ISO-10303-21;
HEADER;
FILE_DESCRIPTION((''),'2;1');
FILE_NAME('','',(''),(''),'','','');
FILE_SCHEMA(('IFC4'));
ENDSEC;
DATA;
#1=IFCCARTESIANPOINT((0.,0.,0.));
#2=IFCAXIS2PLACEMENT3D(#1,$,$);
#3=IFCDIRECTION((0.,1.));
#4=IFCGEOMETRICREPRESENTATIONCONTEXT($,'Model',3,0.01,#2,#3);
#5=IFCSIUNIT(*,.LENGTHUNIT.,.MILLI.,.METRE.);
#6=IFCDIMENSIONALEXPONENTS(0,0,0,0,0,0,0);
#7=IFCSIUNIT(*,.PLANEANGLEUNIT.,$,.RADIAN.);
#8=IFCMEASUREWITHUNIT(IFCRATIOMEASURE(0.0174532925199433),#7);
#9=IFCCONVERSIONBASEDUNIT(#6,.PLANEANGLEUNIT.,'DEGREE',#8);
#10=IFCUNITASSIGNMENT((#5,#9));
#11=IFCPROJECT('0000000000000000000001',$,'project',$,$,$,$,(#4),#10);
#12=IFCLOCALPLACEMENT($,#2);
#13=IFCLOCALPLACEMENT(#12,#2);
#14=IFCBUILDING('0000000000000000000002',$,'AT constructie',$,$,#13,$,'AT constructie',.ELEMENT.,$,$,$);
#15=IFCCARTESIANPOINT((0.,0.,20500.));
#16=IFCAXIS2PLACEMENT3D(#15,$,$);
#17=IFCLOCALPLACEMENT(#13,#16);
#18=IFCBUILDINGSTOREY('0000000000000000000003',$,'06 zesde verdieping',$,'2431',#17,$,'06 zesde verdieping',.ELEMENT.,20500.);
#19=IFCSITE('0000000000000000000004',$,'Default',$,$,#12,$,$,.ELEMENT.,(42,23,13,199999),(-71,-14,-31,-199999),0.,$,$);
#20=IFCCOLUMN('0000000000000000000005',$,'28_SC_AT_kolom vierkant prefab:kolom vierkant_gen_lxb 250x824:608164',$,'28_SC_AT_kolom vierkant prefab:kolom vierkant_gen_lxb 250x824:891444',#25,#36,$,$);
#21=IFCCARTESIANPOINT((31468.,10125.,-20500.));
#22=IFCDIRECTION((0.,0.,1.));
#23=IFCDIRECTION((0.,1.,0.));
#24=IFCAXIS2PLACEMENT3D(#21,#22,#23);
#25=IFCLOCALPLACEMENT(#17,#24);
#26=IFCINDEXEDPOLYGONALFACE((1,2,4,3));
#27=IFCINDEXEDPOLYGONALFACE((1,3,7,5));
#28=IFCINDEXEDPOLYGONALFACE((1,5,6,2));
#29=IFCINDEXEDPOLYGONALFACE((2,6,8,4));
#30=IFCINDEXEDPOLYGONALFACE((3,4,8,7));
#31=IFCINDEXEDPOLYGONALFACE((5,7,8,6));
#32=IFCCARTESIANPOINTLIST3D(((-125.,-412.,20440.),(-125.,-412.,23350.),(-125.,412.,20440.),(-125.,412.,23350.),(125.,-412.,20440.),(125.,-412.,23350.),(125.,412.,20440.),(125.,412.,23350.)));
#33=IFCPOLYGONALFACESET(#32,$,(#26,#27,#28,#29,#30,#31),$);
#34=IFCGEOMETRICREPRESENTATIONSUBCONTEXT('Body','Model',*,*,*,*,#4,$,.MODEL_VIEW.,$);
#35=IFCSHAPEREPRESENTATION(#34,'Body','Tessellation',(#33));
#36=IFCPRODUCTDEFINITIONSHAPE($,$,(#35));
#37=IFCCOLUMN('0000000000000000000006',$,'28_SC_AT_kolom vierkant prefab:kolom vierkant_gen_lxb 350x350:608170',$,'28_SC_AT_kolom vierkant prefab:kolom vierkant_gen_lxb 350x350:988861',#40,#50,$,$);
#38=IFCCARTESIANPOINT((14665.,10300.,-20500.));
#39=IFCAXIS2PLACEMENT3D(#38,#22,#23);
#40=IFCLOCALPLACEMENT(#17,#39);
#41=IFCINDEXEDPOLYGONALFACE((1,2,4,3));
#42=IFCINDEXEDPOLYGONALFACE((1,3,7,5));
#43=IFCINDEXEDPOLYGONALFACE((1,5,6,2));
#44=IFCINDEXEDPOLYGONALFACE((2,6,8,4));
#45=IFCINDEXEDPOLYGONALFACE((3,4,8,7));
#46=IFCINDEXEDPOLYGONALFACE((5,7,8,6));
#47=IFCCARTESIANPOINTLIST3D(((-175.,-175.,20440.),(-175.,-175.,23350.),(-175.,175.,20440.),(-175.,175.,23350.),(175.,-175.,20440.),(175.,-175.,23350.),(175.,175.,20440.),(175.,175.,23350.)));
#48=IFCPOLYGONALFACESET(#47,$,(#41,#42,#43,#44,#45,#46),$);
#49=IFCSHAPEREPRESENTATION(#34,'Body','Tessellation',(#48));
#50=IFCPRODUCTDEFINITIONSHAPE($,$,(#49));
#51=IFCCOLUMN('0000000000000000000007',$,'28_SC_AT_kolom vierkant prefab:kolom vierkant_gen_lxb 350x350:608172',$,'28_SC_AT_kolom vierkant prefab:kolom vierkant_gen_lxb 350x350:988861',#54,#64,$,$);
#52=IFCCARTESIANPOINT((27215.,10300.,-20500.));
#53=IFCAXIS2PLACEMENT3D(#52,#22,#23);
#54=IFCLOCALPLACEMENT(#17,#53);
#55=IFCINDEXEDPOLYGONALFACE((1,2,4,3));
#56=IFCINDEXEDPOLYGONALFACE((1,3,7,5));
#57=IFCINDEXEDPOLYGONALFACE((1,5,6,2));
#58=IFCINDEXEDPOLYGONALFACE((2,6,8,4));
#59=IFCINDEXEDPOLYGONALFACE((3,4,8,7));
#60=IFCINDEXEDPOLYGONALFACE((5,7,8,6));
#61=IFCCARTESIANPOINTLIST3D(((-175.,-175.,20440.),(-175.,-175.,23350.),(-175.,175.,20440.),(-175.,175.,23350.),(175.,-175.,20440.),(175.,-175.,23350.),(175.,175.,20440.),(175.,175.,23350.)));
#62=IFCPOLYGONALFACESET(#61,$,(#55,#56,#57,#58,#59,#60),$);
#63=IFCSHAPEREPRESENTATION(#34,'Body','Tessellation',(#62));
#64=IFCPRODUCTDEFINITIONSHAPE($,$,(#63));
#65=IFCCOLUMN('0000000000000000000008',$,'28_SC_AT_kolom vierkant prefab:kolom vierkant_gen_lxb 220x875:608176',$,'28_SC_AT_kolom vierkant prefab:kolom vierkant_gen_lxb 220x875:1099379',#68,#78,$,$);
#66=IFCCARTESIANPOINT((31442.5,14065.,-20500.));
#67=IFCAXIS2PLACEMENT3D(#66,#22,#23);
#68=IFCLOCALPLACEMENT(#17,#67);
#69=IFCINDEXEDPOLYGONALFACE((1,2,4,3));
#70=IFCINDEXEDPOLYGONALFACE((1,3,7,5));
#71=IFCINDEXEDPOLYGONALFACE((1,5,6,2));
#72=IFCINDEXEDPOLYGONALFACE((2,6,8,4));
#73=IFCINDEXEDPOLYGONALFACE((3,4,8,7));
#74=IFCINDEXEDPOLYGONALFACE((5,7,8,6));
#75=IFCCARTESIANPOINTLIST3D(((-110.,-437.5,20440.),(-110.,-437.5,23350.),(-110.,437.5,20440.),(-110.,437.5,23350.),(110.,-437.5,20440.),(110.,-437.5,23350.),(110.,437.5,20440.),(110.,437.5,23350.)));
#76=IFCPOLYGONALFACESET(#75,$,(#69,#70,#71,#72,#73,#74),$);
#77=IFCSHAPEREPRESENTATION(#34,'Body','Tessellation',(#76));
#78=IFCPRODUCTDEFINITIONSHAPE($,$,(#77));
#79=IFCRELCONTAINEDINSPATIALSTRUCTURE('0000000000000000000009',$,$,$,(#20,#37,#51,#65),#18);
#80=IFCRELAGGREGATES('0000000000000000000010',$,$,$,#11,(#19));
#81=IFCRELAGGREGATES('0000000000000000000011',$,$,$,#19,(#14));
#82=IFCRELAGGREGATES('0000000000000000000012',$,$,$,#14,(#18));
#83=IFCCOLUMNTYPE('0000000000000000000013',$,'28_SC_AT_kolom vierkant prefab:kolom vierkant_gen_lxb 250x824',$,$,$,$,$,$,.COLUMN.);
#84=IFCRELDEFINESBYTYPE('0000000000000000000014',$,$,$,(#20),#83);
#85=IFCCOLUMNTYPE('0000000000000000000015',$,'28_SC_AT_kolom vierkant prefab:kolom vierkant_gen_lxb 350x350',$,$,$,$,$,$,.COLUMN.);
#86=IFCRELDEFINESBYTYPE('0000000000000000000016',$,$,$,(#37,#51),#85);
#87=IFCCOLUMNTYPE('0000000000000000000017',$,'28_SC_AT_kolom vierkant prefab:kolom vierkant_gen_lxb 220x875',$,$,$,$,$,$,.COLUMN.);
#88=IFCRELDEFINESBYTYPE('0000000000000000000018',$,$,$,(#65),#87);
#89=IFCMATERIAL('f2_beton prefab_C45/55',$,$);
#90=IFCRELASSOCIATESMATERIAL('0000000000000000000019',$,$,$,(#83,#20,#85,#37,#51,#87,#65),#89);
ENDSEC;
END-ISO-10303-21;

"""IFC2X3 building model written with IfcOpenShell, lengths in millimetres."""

from ifc_helpers import new_model, entity, si_unit, converted_unit, direction, frame, origin, origin_2d_with_axis, place, context, subcontext, project, spatial, rectangle, extrude, source, transform, mapped, material, type_object, type_shapes, element, save


model = new_model("IFC2X3")

# Units and contexts
model_context = context("Model", 3, precision=0.01, world=origin(), true_north=direction((0.0, 1.0)))
body_context = subcontext(model_context, "Body", "Model", "MODEL_VIEW")
ifc_project = project(units=[si_unit("LENGTHUNIT", "METRE", prefix="MILLI"), converted_unit("PLANEANGLEUNIT", "DEGREE", entity("IfcRatioMeasure", 0.0174532925199433), si_unit("PLANEANGLEUNIT", "RADIAN"), dimensions=[0, 0, 0, 0, 0, 0, 0])], contexts=[model_context])

# Site, building, storey
site_placement = place(None, origin())
site = spatial("IfcSite", under=ifc_project, at=site_placement, Name="Default", CompositionType="ELEMENT", RefLatitude=(42, 23, 13, 199999), RefLongitude=(-71, -14, -31, -199999), RefElevation=0.0)
building_placement = place(site_placement, origin())
building = spatial("IfcBuilding", under=site, at=building_placement, Name="AT constructie", LongName="AT constructie", CompositionType="ELEMENT")
storey_placement = place(building_placement, frame((0.0, 0.0, 20500.0)))
storey = spatial("IfcBuildingStorey", under=building, at=storey_placement, Name="06 zesde verdieping", ObjectType="2431", LongName="06 zesde verdieping", CompositionType="ELEMENT", Elevation=20500.0)

# Columns
ifc_material_1 = material(Name="f2_beton prefab_C45/55")
column_type_1 = type_object("IfcColumnType", Name="28_SC_AT_kolom vierkant prefab:kolom vierkant_gen_lxb 250x824", PredefinedType="COLUMN", material=ifc_material_1)
shared_shape_1 = source(origin(), body_context, "Body", "SweptSolid", [
    extrude(rectangle(XDim=250.0, YDim=824.0, at=origin_2d_with_axis()), frame((0.0, 0.0, 20440.0), z_axis=(0.0, 0.0, 1.0), x_axis=(-1.0, 0.0, 0.0)), (0.0, 0.0, 1.0), 2910.0),
])
type_shapes(column_type_1, [shared_shape_1])
column_1_placement = place(storey_placement, frame((31468.0, 10125.0, -20500.0), z_axis=(0.0, 0.0, 1.0), x_axis=(0.0, 1.0, 0.0)))
element("IfcColumn", 1, at=column_1_placement, inside=storey, type_object=column_type_1, material=ifc_material_1, Name="28_SC_AT_kolom vierkant prefab:kolom vierkant_gen_lxb 250x824:608164", ObjectType="28_SC_AT_kolom vierkant prefab:kolom vierkant_gen_lxb 250x824:891444", context=body_context, shape_type="MappedRepresentation", body=[
    mapped(shared_shape_1, transform((0.0, 0.0, 0.0), scale=1.0)),
])
column_type_2 = type_object("IfcColumnType", Name="28_SC_AT_kolom vierkant prefab:kolom vierkant_gen_lxb 350x350", PredefinedType="COLUMN", material=ifc_material_1)
shared_shape_2 = source(origin(), body_context, "Body", "SweptSolid", [
    extrude(rectangle(XDim=350.0, YDim=350.0, at=origin_2d_with_axis()), frame((0.0, 0.0, 20440.0), z_axis=(0.0, 0.0, 1.0), x_axis=(-1.0, 0.0, 0.0)), (0.0, 0.0, 1.0), 2910.0),
])
type_shapes(column_type_2, [shared_shape_2])
for number, where, z_axis, x_axis, name in (
    (2, (14665.0, 10300.0, -20500.0), (0.0, 0.0, 1.0), (0.0, 1.0, 0.0), "28_SC_AT_kolom vierkant prefab:kolom vierkant_gen_lxb 350x350:608170"),
    (3, (27215.0, 10300.0, -20500.0), (0.0, 0.0, 1.0), (0.0, 1.0, 0.0), "28_SC_AT_kolom vierkant prefab:kolom vierkant_gen_lxb 350x350:608172"),
):
    element("IfcColumn", number, at=place(storey_placement, frame(where, z_axis=z_axis, x_axis=x_axis)), inside=storey, type_object=column_type_2, material=ifc_material_1, Name=name, ObjectType="28_SC_AT_kolom vierkant prefab:kolom vierkant_gen_lxb 350x350:988861", context=body_context, shape_type="MappedRepresentation", body=[
        mapped(shared_shape_2, transform((0.0, 0.0, 0.0), scale=1.0)),
    ])
column_type_3 = type_object("IfcColumnType", Name="28_SC_AT_kolom vierkant prefab:kolom vierkant_gen_lxb 220x875", PredefinedType="COLUMN", material=ifc_material_1)
shared_shape_3 = source(origin(), body_context, "Body", "SweptSolid", [
    extrude(rectangle(XDim=220.0, YDim=875.0, at=origin_2d_with_axis()), frame((0.0, 0.0, 20440.0), z_axis=(0.0, 0.0, 1.0), x_axis=(-1.0, 0.0, 0.0)), (0.0, 0.0, 1.0), 2910.0),
])
type_shapes(column_type_3, [shared_shape_3])
column_2_placement = place(storey_placement, frame((31442.5, 14065.0, -20500.0), z_axis=(0.0, 0.0, 1.0), x_axis=(0.0, 1.0, 0.0)))
element("IfcColumn", 4, at=column_2_placement, inside=storey, type_object=column_type_3, material=ifc_material_1, Name="28_SC_AT_kolom vierkant prefab:kolom vierkant_gen_lxb 220x875:608176", ObjectType="28_SC_AT_kolom vierkant prefab:kolom vierkant_gen_lxb 220x875:1099379", context=body_context, shape_type="MappedRepresentation", body=[
    mapped(shared_shape_3, transform((0.0, 0.0, 0.0), scale=1.0)),
])

save(model, "model.ifc")
